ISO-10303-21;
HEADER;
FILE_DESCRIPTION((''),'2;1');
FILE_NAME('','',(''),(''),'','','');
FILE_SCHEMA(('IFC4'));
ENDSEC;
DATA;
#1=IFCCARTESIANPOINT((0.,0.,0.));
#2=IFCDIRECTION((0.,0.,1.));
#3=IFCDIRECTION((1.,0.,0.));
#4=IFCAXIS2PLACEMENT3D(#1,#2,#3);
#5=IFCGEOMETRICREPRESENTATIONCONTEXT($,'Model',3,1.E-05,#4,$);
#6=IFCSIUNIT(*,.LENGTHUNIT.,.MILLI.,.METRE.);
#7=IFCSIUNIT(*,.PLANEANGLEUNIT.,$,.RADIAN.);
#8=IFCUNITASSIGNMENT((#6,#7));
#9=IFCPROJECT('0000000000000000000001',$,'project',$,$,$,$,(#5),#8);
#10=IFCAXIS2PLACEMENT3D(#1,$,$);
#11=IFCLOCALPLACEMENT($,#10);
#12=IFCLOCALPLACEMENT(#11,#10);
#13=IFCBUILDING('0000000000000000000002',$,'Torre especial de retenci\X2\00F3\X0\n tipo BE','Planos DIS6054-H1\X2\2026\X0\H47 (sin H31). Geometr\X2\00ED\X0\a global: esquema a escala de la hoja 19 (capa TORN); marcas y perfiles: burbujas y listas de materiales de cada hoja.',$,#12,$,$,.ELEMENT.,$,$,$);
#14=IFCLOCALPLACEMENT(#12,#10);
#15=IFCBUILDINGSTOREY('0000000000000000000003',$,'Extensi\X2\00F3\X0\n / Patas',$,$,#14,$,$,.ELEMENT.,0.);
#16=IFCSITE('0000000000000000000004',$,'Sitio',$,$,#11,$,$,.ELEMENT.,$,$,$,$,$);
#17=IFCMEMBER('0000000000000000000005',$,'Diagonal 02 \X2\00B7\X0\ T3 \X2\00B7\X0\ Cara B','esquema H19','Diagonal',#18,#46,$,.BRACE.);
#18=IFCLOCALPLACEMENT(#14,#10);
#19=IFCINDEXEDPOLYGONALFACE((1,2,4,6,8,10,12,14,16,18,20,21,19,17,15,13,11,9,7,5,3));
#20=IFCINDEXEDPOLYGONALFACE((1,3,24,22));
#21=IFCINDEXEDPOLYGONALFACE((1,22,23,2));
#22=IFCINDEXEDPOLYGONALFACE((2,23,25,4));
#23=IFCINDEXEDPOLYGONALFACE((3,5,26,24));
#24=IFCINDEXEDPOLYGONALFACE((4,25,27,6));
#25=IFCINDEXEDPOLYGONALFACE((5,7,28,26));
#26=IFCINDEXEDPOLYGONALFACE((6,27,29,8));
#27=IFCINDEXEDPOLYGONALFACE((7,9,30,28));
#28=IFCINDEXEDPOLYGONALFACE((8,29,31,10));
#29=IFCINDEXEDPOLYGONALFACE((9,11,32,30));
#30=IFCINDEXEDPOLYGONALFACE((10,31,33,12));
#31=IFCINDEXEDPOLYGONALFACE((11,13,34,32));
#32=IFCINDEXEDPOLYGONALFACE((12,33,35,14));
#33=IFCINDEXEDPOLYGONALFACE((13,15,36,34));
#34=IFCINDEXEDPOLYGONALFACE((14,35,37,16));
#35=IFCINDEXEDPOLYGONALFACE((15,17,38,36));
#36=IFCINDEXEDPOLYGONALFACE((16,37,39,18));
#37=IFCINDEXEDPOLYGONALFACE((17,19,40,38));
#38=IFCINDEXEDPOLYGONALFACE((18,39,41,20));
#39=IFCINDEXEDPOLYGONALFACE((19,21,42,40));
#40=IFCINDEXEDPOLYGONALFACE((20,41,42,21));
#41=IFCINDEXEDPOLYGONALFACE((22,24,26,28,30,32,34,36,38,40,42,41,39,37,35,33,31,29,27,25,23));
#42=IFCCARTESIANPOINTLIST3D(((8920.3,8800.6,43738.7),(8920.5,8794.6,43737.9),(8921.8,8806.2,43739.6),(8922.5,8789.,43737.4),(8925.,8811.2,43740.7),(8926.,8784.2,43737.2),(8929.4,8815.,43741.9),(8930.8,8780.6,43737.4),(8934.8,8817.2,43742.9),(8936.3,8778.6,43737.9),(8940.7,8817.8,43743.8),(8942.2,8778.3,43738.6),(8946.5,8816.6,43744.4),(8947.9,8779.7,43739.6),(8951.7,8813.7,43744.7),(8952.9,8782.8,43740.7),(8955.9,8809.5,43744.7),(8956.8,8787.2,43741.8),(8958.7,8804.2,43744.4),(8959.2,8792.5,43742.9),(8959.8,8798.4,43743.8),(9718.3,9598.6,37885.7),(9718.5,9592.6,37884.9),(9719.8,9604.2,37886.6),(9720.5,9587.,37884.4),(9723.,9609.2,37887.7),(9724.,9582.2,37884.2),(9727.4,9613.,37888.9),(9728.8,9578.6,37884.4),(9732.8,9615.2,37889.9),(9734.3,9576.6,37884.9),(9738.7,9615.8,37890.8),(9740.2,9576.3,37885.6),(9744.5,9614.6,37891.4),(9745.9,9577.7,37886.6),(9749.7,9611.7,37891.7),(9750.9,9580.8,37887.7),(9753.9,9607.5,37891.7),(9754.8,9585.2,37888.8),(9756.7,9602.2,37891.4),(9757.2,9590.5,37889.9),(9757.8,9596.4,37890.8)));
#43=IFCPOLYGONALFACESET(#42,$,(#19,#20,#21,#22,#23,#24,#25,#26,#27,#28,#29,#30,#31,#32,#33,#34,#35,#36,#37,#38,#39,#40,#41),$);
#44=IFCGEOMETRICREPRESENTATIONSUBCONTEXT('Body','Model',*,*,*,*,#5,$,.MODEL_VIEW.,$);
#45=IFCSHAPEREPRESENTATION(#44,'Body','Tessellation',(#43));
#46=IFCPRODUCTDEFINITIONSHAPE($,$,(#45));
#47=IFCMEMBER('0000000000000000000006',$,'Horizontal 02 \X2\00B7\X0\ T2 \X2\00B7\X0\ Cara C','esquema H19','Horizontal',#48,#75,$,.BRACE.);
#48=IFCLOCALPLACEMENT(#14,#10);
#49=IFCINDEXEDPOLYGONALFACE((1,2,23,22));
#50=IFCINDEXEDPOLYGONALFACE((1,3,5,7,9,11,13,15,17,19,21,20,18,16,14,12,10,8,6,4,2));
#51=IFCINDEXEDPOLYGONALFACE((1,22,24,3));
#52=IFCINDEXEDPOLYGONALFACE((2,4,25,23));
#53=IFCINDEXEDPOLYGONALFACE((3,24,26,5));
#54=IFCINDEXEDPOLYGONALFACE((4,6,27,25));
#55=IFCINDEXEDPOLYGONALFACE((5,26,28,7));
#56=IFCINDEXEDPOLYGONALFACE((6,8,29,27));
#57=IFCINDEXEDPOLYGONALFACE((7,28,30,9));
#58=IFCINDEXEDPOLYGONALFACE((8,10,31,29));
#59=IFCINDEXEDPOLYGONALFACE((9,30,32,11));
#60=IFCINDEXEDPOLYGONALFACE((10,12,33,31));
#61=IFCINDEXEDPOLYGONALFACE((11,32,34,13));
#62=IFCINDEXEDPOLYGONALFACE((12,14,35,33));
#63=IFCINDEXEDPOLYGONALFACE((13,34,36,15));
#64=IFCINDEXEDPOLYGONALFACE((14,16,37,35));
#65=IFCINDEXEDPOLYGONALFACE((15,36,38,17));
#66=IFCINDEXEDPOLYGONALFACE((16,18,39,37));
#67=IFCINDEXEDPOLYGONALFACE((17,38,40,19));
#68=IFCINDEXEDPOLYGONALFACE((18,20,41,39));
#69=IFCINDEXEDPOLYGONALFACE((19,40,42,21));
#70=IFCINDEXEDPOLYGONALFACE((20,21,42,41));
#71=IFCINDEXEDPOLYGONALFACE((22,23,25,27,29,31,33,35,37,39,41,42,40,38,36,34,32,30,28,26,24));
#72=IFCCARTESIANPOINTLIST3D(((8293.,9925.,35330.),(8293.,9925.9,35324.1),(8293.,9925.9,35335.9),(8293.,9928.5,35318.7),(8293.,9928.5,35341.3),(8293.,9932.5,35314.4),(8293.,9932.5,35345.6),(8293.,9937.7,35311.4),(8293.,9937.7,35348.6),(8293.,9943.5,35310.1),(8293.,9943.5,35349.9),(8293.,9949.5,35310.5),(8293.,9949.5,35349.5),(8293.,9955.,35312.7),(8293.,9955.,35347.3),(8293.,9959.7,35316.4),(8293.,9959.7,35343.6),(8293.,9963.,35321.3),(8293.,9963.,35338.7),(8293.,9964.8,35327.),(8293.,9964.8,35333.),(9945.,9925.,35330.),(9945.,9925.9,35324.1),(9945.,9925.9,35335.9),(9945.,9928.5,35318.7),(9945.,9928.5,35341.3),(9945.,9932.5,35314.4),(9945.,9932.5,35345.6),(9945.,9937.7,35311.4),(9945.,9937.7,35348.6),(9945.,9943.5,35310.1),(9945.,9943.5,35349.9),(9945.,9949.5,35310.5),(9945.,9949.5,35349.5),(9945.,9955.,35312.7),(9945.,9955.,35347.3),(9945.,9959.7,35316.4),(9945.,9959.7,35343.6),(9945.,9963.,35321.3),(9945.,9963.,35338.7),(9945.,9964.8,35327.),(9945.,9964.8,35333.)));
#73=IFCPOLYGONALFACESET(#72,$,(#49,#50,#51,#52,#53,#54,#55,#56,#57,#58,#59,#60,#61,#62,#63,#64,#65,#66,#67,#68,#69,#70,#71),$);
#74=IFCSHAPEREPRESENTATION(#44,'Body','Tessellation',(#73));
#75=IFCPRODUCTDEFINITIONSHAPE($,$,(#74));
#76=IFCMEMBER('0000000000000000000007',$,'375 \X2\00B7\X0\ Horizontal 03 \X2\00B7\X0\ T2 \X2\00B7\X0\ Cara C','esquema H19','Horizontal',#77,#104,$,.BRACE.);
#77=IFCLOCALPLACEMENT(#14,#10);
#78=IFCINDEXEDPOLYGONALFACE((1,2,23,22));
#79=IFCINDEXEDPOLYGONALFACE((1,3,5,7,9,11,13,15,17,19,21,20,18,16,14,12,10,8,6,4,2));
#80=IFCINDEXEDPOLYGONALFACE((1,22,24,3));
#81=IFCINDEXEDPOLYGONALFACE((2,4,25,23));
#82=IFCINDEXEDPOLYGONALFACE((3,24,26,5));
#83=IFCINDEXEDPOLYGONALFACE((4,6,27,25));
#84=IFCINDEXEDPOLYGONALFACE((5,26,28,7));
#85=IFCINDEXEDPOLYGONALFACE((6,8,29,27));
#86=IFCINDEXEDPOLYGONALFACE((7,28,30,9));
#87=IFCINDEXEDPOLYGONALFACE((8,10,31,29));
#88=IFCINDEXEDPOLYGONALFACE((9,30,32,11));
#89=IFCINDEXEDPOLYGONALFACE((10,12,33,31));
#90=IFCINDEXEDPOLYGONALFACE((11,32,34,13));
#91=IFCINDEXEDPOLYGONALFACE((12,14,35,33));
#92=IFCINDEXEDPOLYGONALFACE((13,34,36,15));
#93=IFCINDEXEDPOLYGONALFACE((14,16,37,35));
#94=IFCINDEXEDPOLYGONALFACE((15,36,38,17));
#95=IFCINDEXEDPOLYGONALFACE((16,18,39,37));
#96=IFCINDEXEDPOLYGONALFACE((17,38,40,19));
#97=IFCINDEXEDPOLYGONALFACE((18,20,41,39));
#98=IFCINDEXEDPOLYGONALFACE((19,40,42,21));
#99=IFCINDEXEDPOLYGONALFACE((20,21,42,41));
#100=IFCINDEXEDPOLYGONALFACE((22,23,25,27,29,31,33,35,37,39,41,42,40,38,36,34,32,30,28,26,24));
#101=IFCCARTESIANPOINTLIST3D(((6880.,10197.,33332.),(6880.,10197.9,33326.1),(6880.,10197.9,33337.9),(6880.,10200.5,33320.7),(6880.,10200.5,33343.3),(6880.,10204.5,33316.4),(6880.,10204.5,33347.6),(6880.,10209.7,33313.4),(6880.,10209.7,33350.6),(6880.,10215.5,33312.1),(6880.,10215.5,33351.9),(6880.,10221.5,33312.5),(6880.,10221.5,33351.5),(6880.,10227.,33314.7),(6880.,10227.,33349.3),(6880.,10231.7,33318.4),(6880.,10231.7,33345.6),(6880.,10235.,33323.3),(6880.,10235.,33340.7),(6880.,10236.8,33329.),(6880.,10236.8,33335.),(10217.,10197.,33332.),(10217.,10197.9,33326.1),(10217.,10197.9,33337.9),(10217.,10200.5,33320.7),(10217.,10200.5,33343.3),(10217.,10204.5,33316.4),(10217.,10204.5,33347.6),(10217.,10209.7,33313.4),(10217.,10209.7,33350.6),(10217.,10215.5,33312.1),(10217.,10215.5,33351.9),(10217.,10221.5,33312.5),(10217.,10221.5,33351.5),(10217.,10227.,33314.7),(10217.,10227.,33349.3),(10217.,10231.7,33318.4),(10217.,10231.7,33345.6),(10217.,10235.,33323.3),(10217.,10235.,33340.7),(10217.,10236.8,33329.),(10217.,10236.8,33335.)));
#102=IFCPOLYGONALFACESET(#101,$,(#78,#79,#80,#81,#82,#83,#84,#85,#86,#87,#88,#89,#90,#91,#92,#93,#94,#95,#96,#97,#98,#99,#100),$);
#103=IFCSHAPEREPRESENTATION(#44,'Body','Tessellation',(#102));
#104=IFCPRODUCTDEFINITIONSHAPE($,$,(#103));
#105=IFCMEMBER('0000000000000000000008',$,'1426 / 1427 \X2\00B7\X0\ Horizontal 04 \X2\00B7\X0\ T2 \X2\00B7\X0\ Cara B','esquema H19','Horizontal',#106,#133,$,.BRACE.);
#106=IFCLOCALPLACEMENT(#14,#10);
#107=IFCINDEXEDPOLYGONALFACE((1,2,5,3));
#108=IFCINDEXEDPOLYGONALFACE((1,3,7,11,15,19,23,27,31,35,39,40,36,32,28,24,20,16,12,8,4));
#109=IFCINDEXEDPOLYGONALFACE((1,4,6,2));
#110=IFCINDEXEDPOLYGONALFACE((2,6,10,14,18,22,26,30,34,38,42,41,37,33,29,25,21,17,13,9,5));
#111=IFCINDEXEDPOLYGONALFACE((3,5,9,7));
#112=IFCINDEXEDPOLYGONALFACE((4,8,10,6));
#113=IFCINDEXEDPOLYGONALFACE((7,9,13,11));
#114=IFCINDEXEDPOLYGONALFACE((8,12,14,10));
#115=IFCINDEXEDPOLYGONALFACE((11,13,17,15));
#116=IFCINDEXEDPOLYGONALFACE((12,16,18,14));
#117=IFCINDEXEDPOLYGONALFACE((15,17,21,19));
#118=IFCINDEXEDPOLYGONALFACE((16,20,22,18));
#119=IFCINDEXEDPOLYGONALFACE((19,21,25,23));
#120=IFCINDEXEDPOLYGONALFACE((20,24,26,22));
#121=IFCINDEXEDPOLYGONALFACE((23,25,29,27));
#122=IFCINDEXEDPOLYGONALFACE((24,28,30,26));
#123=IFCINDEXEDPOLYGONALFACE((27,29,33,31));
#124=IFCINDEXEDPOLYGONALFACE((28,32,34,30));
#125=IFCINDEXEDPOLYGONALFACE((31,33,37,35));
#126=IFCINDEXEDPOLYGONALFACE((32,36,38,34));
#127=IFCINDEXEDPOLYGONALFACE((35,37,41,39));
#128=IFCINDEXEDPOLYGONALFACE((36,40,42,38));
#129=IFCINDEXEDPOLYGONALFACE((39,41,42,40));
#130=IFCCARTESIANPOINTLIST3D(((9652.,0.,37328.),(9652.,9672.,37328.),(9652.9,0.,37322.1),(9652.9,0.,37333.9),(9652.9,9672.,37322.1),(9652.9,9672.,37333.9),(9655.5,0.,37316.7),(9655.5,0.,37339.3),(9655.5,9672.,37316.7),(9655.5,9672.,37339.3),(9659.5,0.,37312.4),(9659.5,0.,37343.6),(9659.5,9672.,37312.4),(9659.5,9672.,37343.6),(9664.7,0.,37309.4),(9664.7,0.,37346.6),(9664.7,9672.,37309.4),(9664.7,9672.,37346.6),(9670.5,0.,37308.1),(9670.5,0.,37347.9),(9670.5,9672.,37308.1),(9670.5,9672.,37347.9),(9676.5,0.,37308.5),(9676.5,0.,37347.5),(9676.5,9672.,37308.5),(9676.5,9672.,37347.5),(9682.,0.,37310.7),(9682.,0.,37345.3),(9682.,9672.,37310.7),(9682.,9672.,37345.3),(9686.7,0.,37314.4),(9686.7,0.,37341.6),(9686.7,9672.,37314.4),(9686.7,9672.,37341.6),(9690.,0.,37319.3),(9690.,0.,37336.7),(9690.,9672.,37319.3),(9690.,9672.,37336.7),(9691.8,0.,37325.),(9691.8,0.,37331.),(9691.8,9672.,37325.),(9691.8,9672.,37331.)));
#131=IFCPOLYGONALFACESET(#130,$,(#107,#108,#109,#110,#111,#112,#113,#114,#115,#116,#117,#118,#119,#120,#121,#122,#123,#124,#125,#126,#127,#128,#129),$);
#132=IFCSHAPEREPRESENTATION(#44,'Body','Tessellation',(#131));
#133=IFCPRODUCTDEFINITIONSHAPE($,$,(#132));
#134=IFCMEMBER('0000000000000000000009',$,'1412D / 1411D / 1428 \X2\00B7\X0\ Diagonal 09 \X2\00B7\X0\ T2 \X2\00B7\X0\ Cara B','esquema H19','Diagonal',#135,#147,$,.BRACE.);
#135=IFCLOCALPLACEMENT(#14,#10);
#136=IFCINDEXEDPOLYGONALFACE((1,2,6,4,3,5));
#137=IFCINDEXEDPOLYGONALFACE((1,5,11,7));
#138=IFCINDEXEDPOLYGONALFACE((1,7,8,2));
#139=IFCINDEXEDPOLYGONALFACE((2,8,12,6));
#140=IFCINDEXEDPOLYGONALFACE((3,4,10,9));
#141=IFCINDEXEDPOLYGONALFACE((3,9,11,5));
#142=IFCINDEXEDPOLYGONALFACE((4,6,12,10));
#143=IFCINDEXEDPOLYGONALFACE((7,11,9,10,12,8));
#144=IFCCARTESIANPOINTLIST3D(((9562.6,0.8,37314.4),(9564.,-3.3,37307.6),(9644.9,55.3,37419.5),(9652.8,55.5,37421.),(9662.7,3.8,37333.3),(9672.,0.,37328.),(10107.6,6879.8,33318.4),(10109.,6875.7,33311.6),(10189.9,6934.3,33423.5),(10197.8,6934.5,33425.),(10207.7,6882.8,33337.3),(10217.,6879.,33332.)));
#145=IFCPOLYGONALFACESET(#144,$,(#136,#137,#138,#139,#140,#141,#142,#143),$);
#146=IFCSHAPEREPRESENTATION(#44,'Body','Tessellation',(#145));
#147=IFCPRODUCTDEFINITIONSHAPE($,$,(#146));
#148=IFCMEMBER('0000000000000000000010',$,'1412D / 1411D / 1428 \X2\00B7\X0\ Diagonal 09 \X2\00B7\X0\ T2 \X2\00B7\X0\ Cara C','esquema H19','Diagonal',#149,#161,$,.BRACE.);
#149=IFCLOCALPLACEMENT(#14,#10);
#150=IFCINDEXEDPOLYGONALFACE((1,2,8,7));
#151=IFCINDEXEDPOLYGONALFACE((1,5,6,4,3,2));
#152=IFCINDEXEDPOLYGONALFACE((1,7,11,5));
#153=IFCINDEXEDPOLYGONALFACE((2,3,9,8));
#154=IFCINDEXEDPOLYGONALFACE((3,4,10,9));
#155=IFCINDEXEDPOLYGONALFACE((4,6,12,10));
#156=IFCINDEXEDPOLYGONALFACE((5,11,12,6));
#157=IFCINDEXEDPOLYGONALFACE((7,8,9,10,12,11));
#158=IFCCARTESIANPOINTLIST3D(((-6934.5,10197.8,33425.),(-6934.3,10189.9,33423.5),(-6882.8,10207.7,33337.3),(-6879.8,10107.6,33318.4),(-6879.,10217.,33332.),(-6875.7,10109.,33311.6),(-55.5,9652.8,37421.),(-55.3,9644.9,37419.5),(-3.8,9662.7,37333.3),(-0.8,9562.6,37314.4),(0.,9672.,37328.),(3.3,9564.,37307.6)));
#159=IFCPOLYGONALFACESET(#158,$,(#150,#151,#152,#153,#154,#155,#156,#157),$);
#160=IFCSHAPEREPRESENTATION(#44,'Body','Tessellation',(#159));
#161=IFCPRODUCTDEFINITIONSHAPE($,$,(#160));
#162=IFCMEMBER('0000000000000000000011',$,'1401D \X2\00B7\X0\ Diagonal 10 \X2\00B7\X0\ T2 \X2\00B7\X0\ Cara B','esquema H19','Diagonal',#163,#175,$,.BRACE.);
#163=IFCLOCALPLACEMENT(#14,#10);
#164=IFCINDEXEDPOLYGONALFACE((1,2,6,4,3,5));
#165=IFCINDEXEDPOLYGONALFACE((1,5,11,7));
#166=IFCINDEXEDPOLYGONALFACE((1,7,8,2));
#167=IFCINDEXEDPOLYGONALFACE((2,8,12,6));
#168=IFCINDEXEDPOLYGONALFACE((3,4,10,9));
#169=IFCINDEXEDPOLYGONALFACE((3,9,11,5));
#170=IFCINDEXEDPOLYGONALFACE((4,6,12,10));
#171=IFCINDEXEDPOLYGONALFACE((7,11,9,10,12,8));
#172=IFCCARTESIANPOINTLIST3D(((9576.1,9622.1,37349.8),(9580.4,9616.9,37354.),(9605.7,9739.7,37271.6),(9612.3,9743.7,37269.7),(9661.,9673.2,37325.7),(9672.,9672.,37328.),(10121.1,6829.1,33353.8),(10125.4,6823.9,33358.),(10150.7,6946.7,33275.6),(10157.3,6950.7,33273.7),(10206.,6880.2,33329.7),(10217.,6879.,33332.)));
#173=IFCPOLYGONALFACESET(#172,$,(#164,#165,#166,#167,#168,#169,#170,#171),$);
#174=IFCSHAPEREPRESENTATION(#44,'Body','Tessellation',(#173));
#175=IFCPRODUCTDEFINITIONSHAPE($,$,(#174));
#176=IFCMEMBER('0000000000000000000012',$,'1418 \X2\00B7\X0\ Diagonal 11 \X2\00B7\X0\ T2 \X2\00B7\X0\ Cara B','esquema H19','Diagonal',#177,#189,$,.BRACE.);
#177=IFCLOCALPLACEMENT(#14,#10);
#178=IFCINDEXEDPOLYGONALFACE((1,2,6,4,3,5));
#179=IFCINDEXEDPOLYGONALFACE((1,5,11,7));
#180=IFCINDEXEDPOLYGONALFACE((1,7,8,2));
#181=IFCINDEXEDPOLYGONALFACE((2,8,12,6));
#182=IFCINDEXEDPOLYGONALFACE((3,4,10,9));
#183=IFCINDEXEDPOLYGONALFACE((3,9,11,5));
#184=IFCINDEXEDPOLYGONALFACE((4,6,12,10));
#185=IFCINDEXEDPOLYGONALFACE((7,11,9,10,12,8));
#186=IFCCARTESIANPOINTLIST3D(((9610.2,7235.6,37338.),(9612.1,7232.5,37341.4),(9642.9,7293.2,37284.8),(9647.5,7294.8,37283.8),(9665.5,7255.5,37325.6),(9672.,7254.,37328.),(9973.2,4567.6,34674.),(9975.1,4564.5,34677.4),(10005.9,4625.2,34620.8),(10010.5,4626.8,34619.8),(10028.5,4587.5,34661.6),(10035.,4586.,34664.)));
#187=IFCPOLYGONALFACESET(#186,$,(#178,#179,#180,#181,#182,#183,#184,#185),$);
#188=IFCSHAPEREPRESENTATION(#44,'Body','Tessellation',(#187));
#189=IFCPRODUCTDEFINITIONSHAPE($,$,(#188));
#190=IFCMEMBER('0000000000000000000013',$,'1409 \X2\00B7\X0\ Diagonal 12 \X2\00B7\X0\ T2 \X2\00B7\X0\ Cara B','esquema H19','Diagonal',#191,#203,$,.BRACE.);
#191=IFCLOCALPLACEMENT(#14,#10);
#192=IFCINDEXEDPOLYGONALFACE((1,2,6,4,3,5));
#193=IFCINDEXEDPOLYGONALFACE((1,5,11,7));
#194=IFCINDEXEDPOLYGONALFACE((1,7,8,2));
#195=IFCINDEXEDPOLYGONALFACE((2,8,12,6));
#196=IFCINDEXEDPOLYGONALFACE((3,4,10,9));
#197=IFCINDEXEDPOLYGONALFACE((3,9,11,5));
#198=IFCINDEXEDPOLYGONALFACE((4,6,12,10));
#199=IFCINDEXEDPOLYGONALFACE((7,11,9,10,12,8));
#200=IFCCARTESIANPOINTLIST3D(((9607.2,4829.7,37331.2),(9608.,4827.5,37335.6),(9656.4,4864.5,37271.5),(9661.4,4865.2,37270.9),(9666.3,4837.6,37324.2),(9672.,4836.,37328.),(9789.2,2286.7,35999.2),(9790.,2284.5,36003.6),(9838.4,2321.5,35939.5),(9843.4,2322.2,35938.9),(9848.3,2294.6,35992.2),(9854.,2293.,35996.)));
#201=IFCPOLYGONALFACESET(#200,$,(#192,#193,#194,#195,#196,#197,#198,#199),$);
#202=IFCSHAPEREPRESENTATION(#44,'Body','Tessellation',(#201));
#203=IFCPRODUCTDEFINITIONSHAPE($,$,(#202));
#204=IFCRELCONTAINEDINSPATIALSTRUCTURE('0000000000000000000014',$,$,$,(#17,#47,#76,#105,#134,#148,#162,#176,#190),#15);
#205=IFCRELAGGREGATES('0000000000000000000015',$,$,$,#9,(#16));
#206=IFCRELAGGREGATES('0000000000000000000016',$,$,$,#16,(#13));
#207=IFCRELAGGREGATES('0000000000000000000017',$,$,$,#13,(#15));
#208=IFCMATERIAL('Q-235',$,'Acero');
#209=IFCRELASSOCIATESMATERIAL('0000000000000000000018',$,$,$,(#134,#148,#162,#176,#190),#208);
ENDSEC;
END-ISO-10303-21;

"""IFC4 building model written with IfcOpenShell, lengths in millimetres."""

from ifc_helpers import new_model, si_unit, frame, frame_2d, origin, origin_with_axes, place, context, subcontext, project, spatial, circle, l_section, extrude, material, element, save


model = new_model("IFC4")

# Units and contexts
model_context = context("Model", 3, precision=1e-05, world=origin_with_axes())
body_context = subcontext(model_context, "Body", "Model", "MODEL_VIEW")
ifc_project = project(units=[si_unit("LENGTHUNIT", "METRE", prefix="MILLI"), si_unit("PLANEANGLEUNIT", "RADIAN")], contexts=[model_context])

# Site, building, storey
site_placement = place(None, origin())
site = spatial("IfcSite", under=ifc_project, at=site_placement, Name="Sitio", CompositionType="ELEMENT")
building_placement = place(site_placement, origin())
building = spatial("IfcBuilding", under=site, at=building_placement, Name="Torre especial de retención tipo BE", Description="Planos DIS6054-H1…H47 (sin H31). Geometría global: esquema a escala de la hoja 19 (capa TORN); marcas y perfiles: burbujas y listas de materiales de cada hoja.", CompositionType="ELEMENT")
storey_placement = place(building_placement, origin())
storey = spatial("IfcBuildingStorey", under=building, at=storey_placement, Name="Extensión / Patas", CompositionType="ELEMENT", Elevation=0.0)

# Members
member_1_placement = place(storey_placement, frame((9738.0, 9596.0, 37888.0), z_axis=(-0.133874, -0.133874, 0.981914), x_axis=(-0.699814, -0.68878, -0.189321)))
element("IfcMember", 1, at=member_1_placement, inside=storey, Name="Diagonal 02 · T3 · Cara B", Description="esquema H19", ObjectType="Diagonal", PredefinedType="BRACE", context=body_context, shape_type="SweptSolid", body=[
    extrude(circle(Radius=20.0), None, (0.0, 0.0, 1.0), 5960.8),
])
member_2_placement = place(storey_placement, frame((8293.0, 9945.0, 35330.0), z_axis=(1.0, 0.0, 0.0), x_axis=(0.0, -1.0, 0.0)))
element("IfcMember", 2, at=member_2_placement, inside=storey, Name="Horizontal 02 · T2 · Cara C", Description="esquema H19", ObjectType="Horizontal", PredefinedType="BRACE", context=body_context, shape_type="SweptSolid", body=[
    extrude(circle(Radius=20.0), None, (0.0, 0.0, 1.0), 1652.0),
])
member_3_placement = place(storey_placement, frame((6880.0, 10217.0, 33332.0), z_axis=(1.0, 0.0, 0.0), x_axis=(0.0, -1.0, 0.0)))
element("IfcMember", 3, at=member_3_placement, inside=storey, Name="375 · Horizontal 03 · T2 · Cara C", Description="esquema H19", ObjectType="Horizontal", PredefinedType="BRACE", context=body_context, shape_type="SweptSolid", body=[
    extrude(circle(Radius=20.0), None, (0.0, 0.0, 1.0), 3337.0),
])
member_4_placement = place(storey_placement, frame((9672.0, 0.0, 37328.0), z_axis=(0.0, 1.0, 0.0), x_axis=(-1.0, 0.0, 0.0)))
element("IfcMember", 4, at=member_4_placement, inside=storey, Name="1426 / 1427 · Horizontal 04 · T2 · Cara B", Description="esquema H19", ObjectType="Horizontal", PredefinedType="BRACE", context=body_context, shape_type="SweptSolid", body=[
    extrude(circle(Radius=20.0), None, (0.0, 0.0, 1.0), 9672.0),
])
ifc_material = material(Name="Q-235", Category="Acero")
for number, where, z_axis, x_axis, name in (
    (5, (9672.0, 0.0, 37328.0), (0.068347, 0.862672, -0.501125), (-0.98226, -0.029733, -0.185152), "1412D / 1411D / 1428 · Diagonal 09 · T2 · Cara B"),
    (6, (0.0, 9672.0, 37328.0), (-0.862672, 0.068347, -0.501125), (0.029733, -0.98226, -0.185152), "1412D / 1411D / 1428 · Diagonal 09 · T2 · Cara C"),
):
    element("IfcMember", number, at=place(storey_placement, frame(where, z_axis=z_axis, x_axis=x_axis)), inside=storey, material=ifc_material, Name=name, Description="esquema H19", ObjectType="Diagonal", PredefinedType="BRACE", context=body_context, shape_type="SweptSolid", body=[
        extrude(l_section(Depth=110.0, Width=110.0, Thickness=8.0, at=frame_2d((55.0, 55.0))), None, (0.0, 0.0, 1.0), 7974.1),
    ])
member_5_placement = place(storey_placement, frame((9672.0, 9672.0, 37328.0), z_axis=(0.111095, -0.569338, -0.814563), x_axis=(-0.832645, -0.500787, 0.236463)))
element("IfcMember", 7, at=member_5_placement, inside=storey, material=ifc_material, Name="1401D · Diagonal 10 · T2 · Cara B", Description="esquema H19", ObjectType="Diagonal", PredefinedType="BRACE", context=body_context, shape_type="SweptSolid", body=[
    extrude(l_section(Depth=110.0, Width=110.0, Thickness=8.0, at=frame_2d((55.0, 55.0))), None, (0.0, 0.0, 1.0), 4905.7),
])
member_6_placement = place(storey_placement, frame((9672.0, 7254.0, 37328.0), z_axis=(0.095836, -0.70438, -0.703324), x_axis=(-0.921089, -0.330631, 0.205619)))
element("IfcMember", 8, at=member_6_placement, inside=storey, material=ifc_material, Name="1418 · Diagonal 11 · T2 · Cara B", Description="esquema H19", ObjectType="Diagonal", PredefinedType="BRACE", context=body_context, shape_type="SweptSolid", body=[
    extrude(l_section(Depth=65.0, Width=65.0, Thickness=5.0, at=frame_2d((32.5, 32.5))), None, (0.0, 0.0, 1.0), 3787.7),
])
member_7_placement = place(storey_placement, frame((9672.0, 4836.0, 37328.0), z_axis=(0.063272, -0.884063, -0.463064), x_axis=(-0.98447, -0.131421, 0.116389)))
element("IfcMember", 9, at=member_7_placement, inside=storey, material=ifc_material, Name="1409 · Diagonal 12 · T2 · Cara B", Description="esquema H19", ObjectType="Diagonal", PredefinedType="BRACE", context=body_context, shape_type="SweptSolid", body=[
    extrude(l_section(Depth=65.0, Width=65.0, Thickness=5.0, at=frame_2d((32.5, 32.5))), None, (0.0, 0.0, 1.0), 2876.5),
])

save(model, "model.ifc")
